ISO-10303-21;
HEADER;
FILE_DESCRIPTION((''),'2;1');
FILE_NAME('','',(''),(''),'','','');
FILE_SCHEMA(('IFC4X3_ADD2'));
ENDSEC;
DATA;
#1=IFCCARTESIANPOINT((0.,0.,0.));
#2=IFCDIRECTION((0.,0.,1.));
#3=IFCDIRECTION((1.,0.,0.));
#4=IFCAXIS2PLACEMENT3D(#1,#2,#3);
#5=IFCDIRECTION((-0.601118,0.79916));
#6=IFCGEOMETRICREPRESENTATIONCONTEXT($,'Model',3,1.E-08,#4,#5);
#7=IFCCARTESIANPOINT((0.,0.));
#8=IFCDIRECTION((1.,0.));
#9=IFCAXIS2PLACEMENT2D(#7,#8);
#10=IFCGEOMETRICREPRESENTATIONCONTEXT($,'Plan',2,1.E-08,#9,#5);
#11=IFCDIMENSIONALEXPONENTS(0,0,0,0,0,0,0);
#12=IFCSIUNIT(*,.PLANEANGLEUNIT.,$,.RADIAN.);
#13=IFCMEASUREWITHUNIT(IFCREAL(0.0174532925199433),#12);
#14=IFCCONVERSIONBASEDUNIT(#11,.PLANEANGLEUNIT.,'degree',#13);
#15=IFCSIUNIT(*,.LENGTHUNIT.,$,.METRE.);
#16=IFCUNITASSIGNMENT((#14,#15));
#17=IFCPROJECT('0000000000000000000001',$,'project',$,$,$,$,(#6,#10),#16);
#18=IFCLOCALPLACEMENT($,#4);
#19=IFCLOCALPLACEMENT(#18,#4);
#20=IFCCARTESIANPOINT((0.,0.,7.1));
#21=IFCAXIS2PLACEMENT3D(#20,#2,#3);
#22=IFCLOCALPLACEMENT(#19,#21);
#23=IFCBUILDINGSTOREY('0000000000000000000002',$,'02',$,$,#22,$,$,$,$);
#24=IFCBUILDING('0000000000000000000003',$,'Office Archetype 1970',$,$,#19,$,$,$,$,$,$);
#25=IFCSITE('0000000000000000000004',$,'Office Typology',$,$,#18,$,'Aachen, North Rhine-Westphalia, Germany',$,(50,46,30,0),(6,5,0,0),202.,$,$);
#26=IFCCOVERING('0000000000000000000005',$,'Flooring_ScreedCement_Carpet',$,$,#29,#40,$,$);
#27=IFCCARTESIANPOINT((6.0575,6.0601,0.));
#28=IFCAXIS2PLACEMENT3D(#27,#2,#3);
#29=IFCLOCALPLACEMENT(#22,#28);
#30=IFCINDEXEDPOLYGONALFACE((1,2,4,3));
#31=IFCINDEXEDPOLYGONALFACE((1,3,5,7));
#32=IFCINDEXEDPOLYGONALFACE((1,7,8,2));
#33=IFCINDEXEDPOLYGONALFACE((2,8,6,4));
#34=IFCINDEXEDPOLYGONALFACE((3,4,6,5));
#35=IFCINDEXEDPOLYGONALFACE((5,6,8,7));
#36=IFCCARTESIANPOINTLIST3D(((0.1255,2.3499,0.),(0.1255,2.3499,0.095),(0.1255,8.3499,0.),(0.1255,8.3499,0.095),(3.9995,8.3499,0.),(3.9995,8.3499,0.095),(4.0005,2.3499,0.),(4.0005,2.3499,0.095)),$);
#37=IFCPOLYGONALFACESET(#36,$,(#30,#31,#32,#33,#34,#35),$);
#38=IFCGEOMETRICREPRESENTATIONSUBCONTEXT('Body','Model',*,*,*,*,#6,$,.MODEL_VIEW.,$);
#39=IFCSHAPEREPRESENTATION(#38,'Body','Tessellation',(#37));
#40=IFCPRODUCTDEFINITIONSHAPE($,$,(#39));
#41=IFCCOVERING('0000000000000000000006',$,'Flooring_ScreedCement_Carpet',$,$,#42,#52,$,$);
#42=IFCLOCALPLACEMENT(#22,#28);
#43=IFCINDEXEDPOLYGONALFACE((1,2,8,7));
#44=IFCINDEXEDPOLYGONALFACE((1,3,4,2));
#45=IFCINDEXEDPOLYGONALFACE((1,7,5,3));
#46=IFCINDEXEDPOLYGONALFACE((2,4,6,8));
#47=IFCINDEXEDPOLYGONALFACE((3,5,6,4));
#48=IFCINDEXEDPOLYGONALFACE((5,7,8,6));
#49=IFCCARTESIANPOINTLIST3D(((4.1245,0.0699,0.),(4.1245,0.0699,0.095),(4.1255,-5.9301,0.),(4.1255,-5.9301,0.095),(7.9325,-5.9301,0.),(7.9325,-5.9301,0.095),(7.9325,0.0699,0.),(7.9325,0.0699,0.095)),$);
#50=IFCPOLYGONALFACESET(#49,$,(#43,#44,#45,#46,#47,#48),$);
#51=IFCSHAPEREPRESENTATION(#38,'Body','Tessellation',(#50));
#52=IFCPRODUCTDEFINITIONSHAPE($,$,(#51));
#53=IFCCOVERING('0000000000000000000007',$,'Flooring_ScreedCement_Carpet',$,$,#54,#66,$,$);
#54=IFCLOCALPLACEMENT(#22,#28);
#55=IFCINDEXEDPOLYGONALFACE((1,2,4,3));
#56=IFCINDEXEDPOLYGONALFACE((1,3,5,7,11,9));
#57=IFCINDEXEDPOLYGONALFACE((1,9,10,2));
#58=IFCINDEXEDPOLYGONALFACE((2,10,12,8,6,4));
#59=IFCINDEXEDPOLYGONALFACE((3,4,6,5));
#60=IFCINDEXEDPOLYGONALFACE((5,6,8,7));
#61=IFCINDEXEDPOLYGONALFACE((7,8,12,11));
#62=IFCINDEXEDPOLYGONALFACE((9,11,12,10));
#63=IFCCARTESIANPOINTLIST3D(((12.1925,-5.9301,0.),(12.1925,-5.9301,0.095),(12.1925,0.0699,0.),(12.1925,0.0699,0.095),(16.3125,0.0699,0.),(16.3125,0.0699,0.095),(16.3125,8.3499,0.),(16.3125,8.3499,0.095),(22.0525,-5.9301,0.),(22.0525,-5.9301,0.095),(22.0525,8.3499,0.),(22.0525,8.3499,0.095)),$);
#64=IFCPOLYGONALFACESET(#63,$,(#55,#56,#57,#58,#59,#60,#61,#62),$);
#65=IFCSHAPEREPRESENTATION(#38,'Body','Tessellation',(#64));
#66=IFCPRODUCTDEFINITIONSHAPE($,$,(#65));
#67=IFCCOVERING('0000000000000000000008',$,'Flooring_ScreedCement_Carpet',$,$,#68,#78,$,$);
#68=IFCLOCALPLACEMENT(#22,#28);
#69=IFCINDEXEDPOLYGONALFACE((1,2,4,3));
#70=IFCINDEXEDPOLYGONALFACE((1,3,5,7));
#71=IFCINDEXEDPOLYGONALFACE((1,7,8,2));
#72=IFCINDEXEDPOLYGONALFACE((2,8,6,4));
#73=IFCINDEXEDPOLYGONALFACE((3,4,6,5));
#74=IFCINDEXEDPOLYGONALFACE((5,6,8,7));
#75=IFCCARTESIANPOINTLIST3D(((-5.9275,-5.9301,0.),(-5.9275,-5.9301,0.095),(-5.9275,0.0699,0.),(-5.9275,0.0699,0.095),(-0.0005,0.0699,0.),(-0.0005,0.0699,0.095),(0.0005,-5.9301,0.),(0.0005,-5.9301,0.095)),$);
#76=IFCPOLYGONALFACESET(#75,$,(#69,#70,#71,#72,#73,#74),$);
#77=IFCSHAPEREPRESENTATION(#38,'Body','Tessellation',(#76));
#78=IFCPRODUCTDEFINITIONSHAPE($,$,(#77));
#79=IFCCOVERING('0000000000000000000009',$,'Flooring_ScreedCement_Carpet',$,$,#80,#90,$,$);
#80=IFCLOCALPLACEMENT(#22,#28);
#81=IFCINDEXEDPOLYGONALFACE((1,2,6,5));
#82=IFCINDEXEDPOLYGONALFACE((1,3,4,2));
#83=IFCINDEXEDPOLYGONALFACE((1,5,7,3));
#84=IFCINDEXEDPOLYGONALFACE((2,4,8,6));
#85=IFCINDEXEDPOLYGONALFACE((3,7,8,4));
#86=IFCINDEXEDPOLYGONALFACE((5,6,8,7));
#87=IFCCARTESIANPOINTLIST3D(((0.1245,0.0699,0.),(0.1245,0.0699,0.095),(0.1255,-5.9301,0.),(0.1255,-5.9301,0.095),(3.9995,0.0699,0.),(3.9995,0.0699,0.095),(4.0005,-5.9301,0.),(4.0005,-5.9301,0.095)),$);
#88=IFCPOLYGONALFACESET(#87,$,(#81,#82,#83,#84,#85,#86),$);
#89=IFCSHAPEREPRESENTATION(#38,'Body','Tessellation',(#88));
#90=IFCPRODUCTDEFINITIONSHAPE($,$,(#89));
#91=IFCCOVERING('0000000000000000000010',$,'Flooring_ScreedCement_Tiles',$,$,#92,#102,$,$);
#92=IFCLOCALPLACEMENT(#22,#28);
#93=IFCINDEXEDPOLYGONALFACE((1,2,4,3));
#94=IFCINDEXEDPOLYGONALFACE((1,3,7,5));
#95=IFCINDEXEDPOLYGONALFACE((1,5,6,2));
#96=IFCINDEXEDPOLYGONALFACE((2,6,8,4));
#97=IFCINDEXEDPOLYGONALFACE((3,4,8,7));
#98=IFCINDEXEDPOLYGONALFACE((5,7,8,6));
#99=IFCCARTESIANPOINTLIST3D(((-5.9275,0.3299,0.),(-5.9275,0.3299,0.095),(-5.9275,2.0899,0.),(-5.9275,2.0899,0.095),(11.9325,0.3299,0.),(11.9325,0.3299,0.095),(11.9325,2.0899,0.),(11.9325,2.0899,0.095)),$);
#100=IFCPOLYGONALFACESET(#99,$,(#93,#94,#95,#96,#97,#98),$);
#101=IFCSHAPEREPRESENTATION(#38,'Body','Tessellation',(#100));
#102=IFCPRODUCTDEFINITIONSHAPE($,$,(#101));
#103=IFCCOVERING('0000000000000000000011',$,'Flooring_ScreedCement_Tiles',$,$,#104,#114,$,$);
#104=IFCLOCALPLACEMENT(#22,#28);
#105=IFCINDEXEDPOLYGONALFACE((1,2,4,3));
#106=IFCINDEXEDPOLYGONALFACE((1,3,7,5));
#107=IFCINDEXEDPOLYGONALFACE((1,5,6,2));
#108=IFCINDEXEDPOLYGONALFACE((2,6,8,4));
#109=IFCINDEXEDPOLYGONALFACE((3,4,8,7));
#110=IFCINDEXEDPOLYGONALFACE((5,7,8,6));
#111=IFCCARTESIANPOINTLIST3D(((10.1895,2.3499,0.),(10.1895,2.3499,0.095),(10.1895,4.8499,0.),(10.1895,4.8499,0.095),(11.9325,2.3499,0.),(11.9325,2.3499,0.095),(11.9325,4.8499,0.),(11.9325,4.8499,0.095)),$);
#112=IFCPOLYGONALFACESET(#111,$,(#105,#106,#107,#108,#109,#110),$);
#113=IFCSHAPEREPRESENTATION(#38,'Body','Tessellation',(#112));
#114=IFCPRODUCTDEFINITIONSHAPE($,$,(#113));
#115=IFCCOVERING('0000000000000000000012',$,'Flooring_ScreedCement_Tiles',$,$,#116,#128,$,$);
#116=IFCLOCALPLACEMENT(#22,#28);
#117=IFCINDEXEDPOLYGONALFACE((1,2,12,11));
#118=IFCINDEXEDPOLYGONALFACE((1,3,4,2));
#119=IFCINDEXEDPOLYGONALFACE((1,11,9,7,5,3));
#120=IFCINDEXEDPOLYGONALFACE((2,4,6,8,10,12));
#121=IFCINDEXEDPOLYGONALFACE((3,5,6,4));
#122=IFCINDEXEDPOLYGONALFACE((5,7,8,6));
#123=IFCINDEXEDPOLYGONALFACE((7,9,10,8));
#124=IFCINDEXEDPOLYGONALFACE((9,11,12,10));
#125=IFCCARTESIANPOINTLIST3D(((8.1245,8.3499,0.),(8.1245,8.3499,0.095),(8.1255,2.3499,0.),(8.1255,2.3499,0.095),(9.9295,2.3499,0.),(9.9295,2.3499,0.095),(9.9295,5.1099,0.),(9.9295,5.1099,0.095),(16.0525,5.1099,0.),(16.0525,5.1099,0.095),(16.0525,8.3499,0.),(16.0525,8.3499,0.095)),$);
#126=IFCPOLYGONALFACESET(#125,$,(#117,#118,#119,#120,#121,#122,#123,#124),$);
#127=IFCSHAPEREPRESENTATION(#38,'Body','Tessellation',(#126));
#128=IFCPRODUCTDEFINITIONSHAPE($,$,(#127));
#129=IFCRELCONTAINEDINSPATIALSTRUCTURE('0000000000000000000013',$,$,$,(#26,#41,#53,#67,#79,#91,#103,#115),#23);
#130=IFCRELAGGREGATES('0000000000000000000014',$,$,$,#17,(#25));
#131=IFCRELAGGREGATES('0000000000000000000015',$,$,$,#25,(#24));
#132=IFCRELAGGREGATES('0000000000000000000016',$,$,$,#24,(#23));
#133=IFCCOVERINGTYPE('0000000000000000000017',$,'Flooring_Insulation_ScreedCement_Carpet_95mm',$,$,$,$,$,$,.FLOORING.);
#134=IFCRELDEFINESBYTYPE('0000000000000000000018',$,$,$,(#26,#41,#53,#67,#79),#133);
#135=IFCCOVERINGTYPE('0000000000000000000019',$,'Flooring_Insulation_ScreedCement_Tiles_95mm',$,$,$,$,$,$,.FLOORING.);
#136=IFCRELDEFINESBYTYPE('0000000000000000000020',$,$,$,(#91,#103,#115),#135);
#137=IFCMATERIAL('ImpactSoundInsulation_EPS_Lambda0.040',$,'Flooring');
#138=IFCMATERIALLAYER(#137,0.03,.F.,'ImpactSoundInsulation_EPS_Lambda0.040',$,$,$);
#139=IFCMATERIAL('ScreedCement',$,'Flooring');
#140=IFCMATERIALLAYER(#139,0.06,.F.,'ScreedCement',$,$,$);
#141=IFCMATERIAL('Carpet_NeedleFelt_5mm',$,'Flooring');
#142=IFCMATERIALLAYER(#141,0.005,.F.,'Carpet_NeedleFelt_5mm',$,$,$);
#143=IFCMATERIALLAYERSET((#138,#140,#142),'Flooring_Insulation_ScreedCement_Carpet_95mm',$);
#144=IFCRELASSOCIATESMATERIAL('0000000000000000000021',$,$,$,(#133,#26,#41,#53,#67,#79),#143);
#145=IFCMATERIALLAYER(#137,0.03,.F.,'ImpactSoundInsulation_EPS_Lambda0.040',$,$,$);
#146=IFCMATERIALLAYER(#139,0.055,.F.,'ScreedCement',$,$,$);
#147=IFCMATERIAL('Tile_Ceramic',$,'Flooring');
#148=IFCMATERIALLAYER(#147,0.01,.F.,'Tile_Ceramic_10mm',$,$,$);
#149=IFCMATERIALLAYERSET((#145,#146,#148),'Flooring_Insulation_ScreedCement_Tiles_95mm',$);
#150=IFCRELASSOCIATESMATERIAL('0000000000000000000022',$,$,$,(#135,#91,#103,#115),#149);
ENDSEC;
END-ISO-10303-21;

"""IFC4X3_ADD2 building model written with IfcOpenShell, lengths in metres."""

from ifc_helpers import new_model, entity, si_unit, converted_unit, direction, frame, origin_with_axes, origin_2d_with_axis, place, context, subcontext, project, spatial, line, indexed_curve, outline, extrude, material, layer, layer_set, layer_usage, type_object, element, save


model = new_model("IFC4X3_ADD2")

# Units and contexts
model_context = context("Model", 3, precision=1e-08, world=origin_with_axes(), true_north=direction((-0.601118, 0.79916)))
plan_context = context("Plan", 2, precision=1e-08, world=origin_2d_with_axis(), true_north=direction((-0.601118, 0.79916)))
body_context = subcontext(model_context, "Body", "Model", "MODEL_VIEW")
ifc_project = project(units=[converted_unit("PLANEANGLEUNIT", "degree", entity("IfcReal", 0.0174532925199433), si_unit("PLANEANGLEUNIT", "RADIAN"), dimensions=[0, 0, 0, 0, 0, 0, 0]), si_unit("LENGTHUNIT", "METRE")], contexts=[model_context, plan_context])

# Site, building, storey
site_placement = place(None, origin_with_axes())
site = spatial("IfcSite", under=ifc_project, at=site_placement, Name="Office Typology", LongName="Aachen, North Rhine-Westphalia, Germany", RefLatitude=(50, 46, 30, 0), RefLongitude=(6, 5, 0, 0), RefElevation=202.0)
building_placement = place(site_placement, origin_with_axes())
building = spatial("IfcBuilding", under=site, at=building_placement, Name="Office Archetype 1970")
storey_placement = place(building_placement, frame((0.0, 0.0, 7.1), z_axis=(0.0, 0.0, 1.0), x_axis=(1.0, 0.0, 0.0)))
storey = spatial("IfcBuildingStorey", under=building, at=storey_placement, Name="02")

# Coverings
ifc_material_1 = material(Name="ImpactSoundInsulation_EPS_Lambda0.040", Category="Flooring")
ifc_layer_1 = layer(ifc_material_1, 0.03, ventilated=False, Name="ImpactSoundInsulation_EPS_Lambda0.040")
ifc_material_2 = material(Name="ScreedCement", Category="Flooring")
ifc_layer_2 = layer(ifc_material_2, 0.06, ventilated=False, Name="ScreedCement")
ifc_material_3 = material(Name="Carpet_NeedleFelt_5mm", Category="Flooring")
ifc_layer_3 = layer(ifc_material_3, 0.005, ventilated=False, Name="Carpet_NeedleFelt_5mm")
ifc_layer_set_1 = layer_set([ifc_layer_1, ifc_layer_2, ifc_layer_3], Name="Flooring_Insulation_ScreedCement_Carpet_95mm")
ifc_layer_usage_1 = layer_usage(ifc_layer_set_1, "AXIS3", "POSITIVE", 0.0)
covering_type_1 = type_object("IfcCoveringType", Name="Flooring_Insulation_ScreedCement_Carpet_95mm", PredefinedType="FLOORING", material=ifc_layer_set_1)
covering_1_placement = place(storey_placement, frame((6.0575, 6.0601, 0.0), z_axis=(0.0, 0.0, 1.0), x_axis=(1.0, 0.0, 0.0)))
element("IfcCovering", 1, at=covering_1_placement, inside=storey, type_object=covering_type_1, material=ifc_layer_usage_1, Name="Flooring_ScreedCement_Carpet", context=body_context, shape_type="SweptSolid", body=[
    extrude(outline(indexed_curve([(0.1255, 2.3499), (0.1255, 8.3499), (3.9995, 8.3499), (4.0005, 2.3499)], segments=[line(1, 2, 3, 4, 1)])), origin_with_axes(), (0.0, 0.0, 1.0), 0.095),
])
ifc_layer_usage_2 = layer_usage(ifc_layer_set_1, "AXIS3", "POSITIVE", 0.0)
covering_2_placement = place(storey_placement, frame((6.0575, 6.0601, 0.0), z_axis=(0.0, 0.0, 1.0), x_axis=(1.0, 0.0, 0.0)))
element("IfcCovering", 2, at=covering_2_placement, inside=storey, type_object=covering_type_1, material=ifc_layer_usage_2, Name="Flooring_ScreedCement_Carpet", context=body_context, shape_type="SweptSolid", body=[
    extrude(outline(indexed_curve([(4.1245, 0.0699), (7.9325, 0.0699), (7.9325, -5.9301), (4.1255, -5.9301)], segments=[line(1, 2, 3, 4, 1)])), origin_with_axes(), (0.0, 0.0, 1.0), 0.095),
])
ifc_layer_usage_3 = layer_usage(ifc_layer_set_1, "AXIS3", "POSITIVE", 0.0)
covering_3_placement = place(storey_placement, frame((6.0575, 6.0601, 0.0), z_axis=(0.0, 0.0, 1.0), x_axis=(1.0, 0.0, 0.0)))
element("IfcCovering", 3, at=covering_3_placement, inside=storey, type_object=covering_type_1, material=ifc_layer_usage_3, Name="Flooring_ScreedCement_Carpet", context=body_context, shape_type="SweptSolid", body=[
    extrude(outline(indexed_curve([(16.3125, 8.3499), (22.0525, 8.3499), (22.0525, -5.9301), (12.1925, -5.9301), (12.1925, 0.0699), (16.3125, 0.0699)], segments=[line(1, 2, 3, 4, 5, 6, 1)])), origin_with_axes(), (0.0, 0.0, 1.0), 0.095),
])
ifc_layer_usage_4 = layer_usage(ifc_layer_set_1, "AXIS3", "POSITIVE", 0.0)
covering_4_placement = place(storey_placement, frame((6.0575, 6.0601, 0.0), z_axis=(0.0, 0.0, 1.0), x_axis=(1.0, 0.0, 0.0)))
element("IfcCovering", 4, at=covering_4_placement, inside=storey, type_object=covering_type_1, material=ifc_layer_usage_4, Name="Flooring_ScreedCement_Carpet", context=body_context, shape_type="SweptSolid", body=[
    extrude(outline(indexed_curve([(-5.9275, -5.9301), (-5.9275, 0.0699), (-0.0005, 0.0699), (0.0005, -5.9301)], segments=[line(1, 2, 3, 4, 1)])), origin_with_axes(), (0.0, 0.0, 1.0), 0.095),
])
ifc_layer_usage_5 = layer_usage(ifc_layer_set_1, "AXIS3", "POSITIVE", 0.0)
covering_5_placement = place(storey_placement, frame((6.0575, 6.0601, 0.0), z_axis=(0.0, 0.0, 1.0), x_axis=(1.0, 0.0, 0.0)))
element("IfcCovering", 5, at=covering_5_placement, inside=storey, type_object=covering_type_1, material=ifc_layer_usage_5, Name="Flooring_ScreedCement_Carpet", context=body_context, shape_type="SweptSolid", body=[
    extrude(outline(indexed_curve([(0.1255, -5.9301), (0.1245, 0.0699), (3.9995, 0.0699), (4.0005, -5.9301)], segments=[line(1, 2, 3, 4, 1)])), origin_with_axes(), (0.0, 0.0, 1.0), 0.095),
])
ifc_layer_4 = layer(ifc_material_1, 0.03, ventilated=False, Name="ImpactSoundInsulation_EPS_Lambda0.040")
ifc_layer_5 = layer(ifc_material_2, 0.055, ventilated=False, Name="ScreedCement")
ifc_material_4 = material(Name="Tile_Ceramic", Category="Flooring")
ifc_layer_6 = layer(ifc_material_4, 0.01, ventilated=False, Name="Tile_Ceramic_10mm")
ifc_layer_set_2 = layer_set([ifc_layer_4, ifc_layer_5, ifc_layer_6], Name="Flooring_Insulation_ScreedCement_Tiles_95mm")
ifc_layer_usage_6 = layer_usage(ifc_layer_set_2, "AXIS3", "POSITIVE", 0.0)
covering_type_2 = type_object("IfcCoveringType", Name="Flooring_Insulation_ScreedCement_Tiles_95mm", PredefinedType="FLOORING", material=ifc_layer_set_2)
covering_6_placement = place(storey_placement, frame((6.0575, 6.0601, 0.0), z_axis=(0.0, 0.0, 1.0), x_axis=(1.0, 0.0, 0.0)))
element("IfcCovering", 6, at=covering_6_placement, inside=storey, type_object=covering_type_2, material=ifc_layer_usage_6, Name="Flooring_ScreedCement_Tiles", context=body_context, shape_type="SweptSolid", body=[
    extrude(outline(indexed_curve([(-5.9275, 0.3299), (-5.9275, 2.0899), (11.9325, 2.0899), (11.9325, 0.3299)], segments=[line(1, 2, 3, 4, 1)])), None, (0.0, 0.0, 1.0), 0.095),
])
ifc_layer_usage_7 = layer_usage(ifc_layer_set_2, "AXIS3", "POSITIVE", 0.0)
covering_7_placement = place(storey_placement, frame((6.0575, 6.0601, 0.0), z_axis=(0.0, 0.0, 1.0), x_axis=(1.0, 0.0, 0.0)))
element("IfcCovering", 7, at=covering_7_placement, inside=storey, type_object=covering_type_2, material=ifc_layer_usage_7, Name="Flooring_ScreedCement_Tiles", context=body_context, shape_type="SweptSolid", body=[
    extrude(outline(indexed_curve([(11.9325, 4.8499), (11.9325, 2.3499), (10.1895, 2.3499), (10.1895, 4.8499)], segments=[line(1, 2, 3, 4, 1)])), None, (0.0, 0.0, 1.0), 0.095),
])
ifc_layer_usage_8 = layer_usage(ifc_layer_set_2, "AXIS3", "POSITIVE", 0.0)
covering_8_placement = place(storey_placement, frame((6.0575, 6.0601, 0.0), z_axis=(0.0, 0.0, 1.0), x_axis=(1.0, 0.0, 0.0)))
element("IfcCovering", 8, at=covering_8_placement, inside=storey, type_object=covering_type_2, material=ifc_layer_usage_8, Name="Flooring_ScreedCement_Tiles", context=body_context, shape_type="SweptSolid", body=[
    extrude(outline(indexed_curve([(9.9295, 2.3499), (8.1255, 2.3499), (8.1245, 8.3499), (16.0525, 8.3499), (16.0525, 5.1099), (9.9295, 5.1099)], segments=[line(1, 2, 3, 4, 5, 6, 1)])), None, (0.0, 0.0, 1.0), 0.095),
])

save(model, "model.ifc")
